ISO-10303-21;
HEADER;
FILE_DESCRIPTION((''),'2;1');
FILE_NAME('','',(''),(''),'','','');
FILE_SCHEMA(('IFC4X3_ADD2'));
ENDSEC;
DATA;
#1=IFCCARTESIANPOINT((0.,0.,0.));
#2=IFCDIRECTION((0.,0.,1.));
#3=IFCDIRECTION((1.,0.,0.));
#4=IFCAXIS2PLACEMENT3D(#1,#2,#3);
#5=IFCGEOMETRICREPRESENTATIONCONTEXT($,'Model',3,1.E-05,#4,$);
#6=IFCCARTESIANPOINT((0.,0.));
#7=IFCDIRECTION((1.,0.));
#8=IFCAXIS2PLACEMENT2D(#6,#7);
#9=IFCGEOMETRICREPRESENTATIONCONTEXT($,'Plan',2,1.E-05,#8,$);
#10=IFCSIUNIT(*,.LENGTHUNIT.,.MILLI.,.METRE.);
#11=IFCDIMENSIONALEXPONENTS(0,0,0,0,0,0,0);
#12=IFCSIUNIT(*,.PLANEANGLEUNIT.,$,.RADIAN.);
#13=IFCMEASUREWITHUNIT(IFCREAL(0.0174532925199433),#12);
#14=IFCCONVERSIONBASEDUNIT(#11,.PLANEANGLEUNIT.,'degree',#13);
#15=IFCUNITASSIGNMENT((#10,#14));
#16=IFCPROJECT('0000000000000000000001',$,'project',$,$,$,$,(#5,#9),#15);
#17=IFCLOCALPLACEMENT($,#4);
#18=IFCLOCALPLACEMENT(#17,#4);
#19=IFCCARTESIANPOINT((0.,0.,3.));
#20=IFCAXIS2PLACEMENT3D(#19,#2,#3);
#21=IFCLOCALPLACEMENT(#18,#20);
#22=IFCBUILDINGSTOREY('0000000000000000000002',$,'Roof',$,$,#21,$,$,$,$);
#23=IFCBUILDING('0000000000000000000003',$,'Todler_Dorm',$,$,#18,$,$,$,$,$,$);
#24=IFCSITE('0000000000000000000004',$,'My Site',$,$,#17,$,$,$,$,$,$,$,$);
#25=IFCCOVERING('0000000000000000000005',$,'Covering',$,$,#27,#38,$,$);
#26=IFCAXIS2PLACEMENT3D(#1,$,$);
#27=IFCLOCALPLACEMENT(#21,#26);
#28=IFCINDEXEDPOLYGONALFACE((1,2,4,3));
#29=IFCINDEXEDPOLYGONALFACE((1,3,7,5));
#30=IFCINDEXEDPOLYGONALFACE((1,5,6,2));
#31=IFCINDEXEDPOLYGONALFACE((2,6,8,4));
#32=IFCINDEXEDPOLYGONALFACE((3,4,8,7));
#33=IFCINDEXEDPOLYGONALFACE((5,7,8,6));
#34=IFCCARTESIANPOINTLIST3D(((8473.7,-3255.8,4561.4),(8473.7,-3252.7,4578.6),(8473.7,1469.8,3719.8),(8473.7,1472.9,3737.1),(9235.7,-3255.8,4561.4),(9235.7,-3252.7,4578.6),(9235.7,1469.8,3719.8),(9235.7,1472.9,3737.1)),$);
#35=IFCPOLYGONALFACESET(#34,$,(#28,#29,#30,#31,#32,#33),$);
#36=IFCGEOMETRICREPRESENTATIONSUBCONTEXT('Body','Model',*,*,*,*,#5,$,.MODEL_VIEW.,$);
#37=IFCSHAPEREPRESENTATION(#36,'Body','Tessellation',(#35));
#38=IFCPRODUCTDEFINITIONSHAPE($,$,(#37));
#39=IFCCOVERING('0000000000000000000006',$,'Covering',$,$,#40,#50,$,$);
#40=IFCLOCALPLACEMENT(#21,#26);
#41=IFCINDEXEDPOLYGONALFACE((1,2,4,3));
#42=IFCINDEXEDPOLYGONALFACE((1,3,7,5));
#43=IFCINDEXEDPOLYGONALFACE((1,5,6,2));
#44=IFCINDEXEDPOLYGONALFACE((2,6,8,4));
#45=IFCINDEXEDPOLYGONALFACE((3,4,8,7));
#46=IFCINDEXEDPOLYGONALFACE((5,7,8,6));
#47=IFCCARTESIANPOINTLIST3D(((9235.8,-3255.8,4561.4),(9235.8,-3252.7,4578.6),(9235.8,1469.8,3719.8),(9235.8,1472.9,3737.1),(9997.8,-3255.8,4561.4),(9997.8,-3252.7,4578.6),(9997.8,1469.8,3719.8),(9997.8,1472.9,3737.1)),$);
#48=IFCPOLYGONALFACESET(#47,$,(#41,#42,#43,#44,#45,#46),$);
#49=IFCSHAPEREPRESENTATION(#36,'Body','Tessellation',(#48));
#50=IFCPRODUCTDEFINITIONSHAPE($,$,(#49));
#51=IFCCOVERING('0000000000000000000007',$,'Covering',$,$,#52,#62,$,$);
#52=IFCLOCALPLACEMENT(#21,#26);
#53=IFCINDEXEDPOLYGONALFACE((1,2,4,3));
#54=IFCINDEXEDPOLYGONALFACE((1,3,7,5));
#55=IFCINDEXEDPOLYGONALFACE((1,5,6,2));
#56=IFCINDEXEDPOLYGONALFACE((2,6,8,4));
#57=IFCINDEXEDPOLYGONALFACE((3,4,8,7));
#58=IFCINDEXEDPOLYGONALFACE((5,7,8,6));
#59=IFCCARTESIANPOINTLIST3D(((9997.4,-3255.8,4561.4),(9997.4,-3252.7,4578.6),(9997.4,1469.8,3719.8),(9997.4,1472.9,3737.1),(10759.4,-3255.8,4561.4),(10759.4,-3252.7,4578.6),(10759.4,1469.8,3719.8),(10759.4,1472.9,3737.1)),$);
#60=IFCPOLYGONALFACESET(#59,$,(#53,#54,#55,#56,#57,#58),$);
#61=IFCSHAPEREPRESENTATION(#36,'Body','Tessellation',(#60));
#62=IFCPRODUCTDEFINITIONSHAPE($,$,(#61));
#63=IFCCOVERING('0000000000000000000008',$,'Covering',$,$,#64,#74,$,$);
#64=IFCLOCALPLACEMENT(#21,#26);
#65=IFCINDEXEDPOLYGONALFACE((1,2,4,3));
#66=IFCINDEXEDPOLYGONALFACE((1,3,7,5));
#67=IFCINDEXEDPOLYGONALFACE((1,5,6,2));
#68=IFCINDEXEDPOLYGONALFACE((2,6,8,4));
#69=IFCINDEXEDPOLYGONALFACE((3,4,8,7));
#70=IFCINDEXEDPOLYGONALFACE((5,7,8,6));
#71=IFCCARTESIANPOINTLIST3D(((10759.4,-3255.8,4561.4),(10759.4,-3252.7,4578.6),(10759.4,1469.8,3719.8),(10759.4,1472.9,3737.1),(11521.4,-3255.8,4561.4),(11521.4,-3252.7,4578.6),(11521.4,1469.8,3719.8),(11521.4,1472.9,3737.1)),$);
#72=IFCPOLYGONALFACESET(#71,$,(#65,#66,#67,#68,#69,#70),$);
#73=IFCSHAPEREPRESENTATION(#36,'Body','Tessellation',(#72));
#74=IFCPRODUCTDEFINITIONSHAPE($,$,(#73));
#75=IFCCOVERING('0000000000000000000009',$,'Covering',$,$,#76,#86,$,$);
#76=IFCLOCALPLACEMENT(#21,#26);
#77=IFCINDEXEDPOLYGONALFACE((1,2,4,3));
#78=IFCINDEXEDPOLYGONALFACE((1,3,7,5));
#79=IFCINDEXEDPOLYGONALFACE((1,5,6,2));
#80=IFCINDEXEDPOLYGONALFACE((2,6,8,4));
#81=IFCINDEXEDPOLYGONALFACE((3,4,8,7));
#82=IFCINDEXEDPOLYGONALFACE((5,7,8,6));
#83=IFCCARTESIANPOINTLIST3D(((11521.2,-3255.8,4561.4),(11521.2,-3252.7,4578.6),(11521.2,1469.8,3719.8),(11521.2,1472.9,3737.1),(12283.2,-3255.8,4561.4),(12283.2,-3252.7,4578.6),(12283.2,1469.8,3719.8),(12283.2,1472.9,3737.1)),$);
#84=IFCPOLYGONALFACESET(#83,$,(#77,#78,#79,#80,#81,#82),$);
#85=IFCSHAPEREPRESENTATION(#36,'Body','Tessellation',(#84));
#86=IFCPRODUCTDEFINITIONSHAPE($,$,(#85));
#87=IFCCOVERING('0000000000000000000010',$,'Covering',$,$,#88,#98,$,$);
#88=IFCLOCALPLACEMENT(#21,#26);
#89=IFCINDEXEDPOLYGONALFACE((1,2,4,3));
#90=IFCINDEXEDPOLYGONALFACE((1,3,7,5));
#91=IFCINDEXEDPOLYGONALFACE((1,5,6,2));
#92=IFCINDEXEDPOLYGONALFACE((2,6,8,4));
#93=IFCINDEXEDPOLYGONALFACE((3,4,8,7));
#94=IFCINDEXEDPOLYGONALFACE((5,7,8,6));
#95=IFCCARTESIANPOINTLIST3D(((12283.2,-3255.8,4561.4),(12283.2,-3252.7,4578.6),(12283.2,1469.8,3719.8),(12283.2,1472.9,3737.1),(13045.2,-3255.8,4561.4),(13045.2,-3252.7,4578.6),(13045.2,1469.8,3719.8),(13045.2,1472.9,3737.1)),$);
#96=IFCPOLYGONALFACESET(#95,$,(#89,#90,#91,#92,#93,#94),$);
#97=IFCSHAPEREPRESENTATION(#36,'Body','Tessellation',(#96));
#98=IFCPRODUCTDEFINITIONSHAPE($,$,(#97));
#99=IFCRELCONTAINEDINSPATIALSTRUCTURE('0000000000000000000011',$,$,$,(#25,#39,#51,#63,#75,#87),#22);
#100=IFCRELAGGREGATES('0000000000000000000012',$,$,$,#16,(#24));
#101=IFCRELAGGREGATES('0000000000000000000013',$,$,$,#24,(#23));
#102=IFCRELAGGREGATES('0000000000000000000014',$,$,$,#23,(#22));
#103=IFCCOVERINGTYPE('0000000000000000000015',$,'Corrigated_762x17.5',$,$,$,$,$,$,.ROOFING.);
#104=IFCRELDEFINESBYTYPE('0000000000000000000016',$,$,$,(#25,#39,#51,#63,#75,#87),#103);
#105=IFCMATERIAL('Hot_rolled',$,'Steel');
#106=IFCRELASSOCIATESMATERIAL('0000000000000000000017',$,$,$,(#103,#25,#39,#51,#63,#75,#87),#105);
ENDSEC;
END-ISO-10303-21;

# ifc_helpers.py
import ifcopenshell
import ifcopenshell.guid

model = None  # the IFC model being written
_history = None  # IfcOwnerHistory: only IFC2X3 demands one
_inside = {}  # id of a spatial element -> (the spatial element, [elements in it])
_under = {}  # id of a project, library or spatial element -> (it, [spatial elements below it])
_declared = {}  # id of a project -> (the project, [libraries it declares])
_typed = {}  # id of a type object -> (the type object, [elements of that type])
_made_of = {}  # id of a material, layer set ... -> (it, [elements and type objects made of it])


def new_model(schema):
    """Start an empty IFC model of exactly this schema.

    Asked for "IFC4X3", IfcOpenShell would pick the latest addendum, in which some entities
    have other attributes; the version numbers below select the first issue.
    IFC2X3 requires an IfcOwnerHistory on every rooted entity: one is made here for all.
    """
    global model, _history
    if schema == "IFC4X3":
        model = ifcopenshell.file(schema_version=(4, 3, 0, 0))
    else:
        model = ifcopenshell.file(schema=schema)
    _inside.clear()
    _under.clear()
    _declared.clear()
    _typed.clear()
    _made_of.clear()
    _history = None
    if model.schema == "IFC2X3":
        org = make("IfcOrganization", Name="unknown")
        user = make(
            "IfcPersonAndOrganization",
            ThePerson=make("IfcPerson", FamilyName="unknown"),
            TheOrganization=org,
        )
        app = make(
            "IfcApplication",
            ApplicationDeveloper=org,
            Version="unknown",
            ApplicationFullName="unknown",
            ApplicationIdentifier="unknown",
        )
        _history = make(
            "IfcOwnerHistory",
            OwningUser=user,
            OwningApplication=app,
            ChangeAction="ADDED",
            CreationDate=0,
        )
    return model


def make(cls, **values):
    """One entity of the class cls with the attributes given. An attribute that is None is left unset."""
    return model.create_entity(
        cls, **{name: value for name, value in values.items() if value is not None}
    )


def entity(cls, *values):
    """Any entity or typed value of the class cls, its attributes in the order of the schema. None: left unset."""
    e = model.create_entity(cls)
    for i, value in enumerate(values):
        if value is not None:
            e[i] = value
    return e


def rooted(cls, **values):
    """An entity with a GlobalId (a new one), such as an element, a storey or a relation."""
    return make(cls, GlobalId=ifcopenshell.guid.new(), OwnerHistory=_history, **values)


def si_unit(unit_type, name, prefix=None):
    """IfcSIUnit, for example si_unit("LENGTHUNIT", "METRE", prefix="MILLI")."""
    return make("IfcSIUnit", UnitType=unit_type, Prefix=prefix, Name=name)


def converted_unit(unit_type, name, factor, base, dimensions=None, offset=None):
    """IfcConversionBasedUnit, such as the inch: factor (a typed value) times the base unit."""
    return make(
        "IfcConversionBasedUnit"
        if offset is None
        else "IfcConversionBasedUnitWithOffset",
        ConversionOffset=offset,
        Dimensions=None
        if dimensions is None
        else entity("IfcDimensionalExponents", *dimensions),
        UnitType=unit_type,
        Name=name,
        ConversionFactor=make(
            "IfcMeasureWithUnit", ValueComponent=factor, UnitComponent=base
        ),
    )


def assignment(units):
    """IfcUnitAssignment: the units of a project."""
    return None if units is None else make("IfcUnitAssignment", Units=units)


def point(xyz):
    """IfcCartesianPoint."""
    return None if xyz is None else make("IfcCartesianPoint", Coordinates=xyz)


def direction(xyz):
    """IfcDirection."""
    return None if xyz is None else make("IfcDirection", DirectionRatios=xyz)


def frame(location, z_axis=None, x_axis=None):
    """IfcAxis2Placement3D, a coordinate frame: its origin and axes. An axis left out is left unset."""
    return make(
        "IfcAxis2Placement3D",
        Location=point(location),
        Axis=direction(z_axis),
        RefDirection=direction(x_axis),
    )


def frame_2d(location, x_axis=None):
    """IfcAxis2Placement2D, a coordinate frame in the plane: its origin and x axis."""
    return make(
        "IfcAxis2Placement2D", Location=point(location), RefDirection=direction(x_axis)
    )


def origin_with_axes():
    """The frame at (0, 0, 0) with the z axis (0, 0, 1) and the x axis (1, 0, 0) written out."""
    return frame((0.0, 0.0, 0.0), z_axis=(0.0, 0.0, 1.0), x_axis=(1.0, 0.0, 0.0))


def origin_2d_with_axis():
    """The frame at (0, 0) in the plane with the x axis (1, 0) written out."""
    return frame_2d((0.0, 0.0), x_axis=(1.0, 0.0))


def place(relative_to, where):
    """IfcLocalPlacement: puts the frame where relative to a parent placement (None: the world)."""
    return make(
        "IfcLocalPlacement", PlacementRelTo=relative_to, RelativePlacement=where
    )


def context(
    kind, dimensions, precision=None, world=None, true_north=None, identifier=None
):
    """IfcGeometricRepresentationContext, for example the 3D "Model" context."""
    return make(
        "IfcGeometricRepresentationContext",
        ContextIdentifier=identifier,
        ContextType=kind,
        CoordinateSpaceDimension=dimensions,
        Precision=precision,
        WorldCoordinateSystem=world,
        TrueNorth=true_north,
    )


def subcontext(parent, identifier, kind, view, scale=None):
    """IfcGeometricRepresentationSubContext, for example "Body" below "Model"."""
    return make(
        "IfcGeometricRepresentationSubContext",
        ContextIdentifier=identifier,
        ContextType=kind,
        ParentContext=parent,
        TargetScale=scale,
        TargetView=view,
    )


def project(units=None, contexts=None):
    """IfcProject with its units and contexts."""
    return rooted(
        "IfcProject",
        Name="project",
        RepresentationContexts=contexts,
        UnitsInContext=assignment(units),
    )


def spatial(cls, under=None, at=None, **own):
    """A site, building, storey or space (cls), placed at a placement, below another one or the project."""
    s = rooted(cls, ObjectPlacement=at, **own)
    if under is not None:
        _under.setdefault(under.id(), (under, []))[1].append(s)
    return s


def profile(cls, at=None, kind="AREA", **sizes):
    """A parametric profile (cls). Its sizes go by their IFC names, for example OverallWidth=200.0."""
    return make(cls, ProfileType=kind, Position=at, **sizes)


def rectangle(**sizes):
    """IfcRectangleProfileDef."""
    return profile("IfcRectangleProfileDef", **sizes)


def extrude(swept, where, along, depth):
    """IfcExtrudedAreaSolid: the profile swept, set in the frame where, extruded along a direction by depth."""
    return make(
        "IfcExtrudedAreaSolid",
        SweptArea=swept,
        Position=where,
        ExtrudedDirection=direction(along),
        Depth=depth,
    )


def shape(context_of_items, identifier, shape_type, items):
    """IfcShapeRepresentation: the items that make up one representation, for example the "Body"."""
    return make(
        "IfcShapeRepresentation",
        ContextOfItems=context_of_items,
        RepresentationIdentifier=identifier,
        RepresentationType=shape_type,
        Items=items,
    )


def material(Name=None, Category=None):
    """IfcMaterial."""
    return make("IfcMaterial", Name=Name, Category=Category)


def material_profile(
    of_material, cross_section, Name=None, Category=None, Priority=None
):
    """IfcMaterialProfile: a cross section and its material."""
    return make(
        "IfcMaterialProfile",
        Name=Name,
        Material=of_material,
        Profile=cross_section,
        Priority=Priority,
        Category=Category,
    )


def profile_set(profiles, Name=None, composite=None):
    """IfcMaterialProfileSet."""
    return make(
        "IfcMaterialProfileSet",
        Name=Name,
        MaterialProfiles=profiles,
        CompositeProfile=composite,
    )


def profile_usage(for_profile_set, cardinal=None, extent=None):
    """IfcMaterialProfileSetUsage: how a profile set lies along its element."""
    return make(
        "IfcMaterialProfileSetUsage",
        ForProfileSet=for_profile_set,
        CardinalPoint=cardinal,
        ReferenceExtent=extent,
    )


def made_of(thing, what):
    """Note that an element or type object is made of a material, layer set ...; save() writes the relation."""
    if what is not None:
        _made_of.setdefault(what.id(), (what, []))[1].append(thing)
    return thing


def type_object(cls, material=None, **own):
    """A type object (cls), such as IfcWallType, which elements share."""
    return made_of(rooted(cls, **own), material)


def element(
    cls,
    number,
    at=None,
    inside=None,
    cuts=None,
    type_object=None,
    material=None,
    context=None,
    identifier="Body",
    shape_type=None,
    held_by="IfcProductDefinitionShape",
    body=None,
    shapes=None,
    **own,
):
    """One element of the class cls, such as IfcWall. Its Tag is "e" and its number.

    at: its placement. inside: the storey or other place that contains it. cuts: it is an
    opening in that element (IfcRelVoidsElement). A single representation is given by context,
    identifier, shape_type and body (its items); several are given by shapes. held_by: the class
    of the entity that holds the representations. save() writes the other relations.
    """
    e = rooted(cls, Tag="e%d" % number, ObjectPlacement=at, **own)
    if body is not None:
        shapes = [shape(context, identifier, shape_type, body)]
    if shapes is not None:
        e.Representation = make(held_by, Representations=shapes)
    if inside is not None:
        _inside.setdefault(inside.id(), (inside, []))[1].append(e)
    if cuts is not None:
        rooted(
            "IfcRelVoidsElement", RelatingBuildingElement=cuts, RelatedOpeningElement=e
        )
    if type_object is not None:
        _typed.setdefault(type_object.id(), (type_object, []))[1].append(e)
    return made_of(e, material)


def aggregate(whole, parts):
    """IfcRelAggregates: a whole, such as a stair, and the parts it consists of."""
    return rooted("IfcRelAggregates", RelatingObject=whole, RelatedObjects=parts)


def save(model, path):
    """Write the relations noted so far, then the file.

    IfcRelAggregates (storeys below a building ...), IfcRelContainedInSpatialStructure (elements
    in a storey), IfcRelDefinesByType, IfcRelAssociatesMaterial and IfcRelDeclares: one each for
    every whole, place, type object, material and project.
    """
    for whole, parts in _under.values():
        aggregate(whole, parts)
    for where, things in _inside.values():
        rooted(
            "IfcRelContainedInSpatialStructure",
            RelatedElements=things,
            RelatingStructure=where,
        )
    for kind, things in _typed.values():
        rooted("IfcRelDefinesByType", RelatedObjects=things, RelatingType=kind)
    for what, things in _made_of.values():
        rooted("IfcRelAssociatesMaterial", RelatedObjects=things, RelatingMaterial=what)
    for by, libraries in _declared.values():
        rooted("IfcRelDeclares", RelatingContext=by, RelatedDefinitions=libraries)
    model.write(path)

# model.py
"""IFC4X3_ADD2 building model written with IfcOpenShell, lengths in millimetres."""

from ifc_helpers import new_model, entity, si_unit, converted_unit, frame, origin_with_axes, origin_2d_with_axis, place, context, subcontext, project, spatial, rectangle, extrude, material, material_profile, profile_set, profile_usage, type_object, element, save


model = new_model("IFC4X3_ADD2")

# Units and contexts
model_context = context("Model", 3, precision=1e-05, world=origin_with_axes())
plan_context = context("Plan", 2, precision=1e-05, world=origin_2d_with_axis())
body_context = subcontext(model_context, "Body", "Model", "MODEL_VIEW")
ifc_project = project(units=[si_unit("LENGTHUNIT", "METRE", prefix="MILLI"), converted_unit("PLANEANGLEUNIT", "degree", entity("IfcReal", 0.0174532925199433), si_unit("PLANEANGLEUNIT", "RADIAN"), dimensions=[0, 0, 0, 0, 0, 0, 0])], contexts=[model_context, plan_context])

# Site, building, storey
site_placement = place(None, origin_with_axes())
site = spatial("IfcSite", under=ifc_project, at=site_placement, Name="My Site")
building_placement = place(site_placement, origin_with_axes())
building = spatial("IfcBuilding", under=site, at=building_placement, Name="Todler_Dorm")
storey_placement = place(building_placement, frame((0.0, 0.0, 3.0), z_axis=(0.0, 0.0, 1.0), x_axis=(1.0, 0.0, 0.0)))
storey = spatial("IfcBuildingStorey", under=building, at=storey_placement, Name="Roof")

# Coverings
ifc_material_1 = material(Name="Hot_rolled", Category="Steel")
ifc_material_profile = material_profile(ifc_material_1, rectangle(XDim=762.0, YDim=17.5))
ifc_profile_set = profile_set([ifc_material_profile])
covering_type = type_object("IfcCoveringType", Name="Corrigated_762x17.5", PredefinedType="ROOFING", material=ifc_profile_set)
ifc_profile_usage_1 = profile_usage(ifc_profile_set, cardinal=5)
covering_1_placement = place(storey_placement, frame((8854.7, 1471.4, 3728.4), z_axis=(0.0, -0.98451, 0.175329), x_axis=(1.0, 0.0, 0.0)))
element("IfcCovering", 1, at=covering_1_placement, inside=storey, type_object=covering_type, material=ifc_profile_usage_1, Name="Covering", context=body_context, shape_type="SweptSolid", body=[
    extrude(rectangle(XDim=762.0, YDim=17.5), origin_with_axes(), (0.0, 0.0, 1.0), 4800.0),
])
ifc_profile_usage_2 = profile_usage(ifc_profile_set, cardinal=5)
covering_2_placement = place(storey_placement, frame((9616.8, 1471.4, 3728.4), z_axis=(0.0, -0.98451, 0.175329), x_axis=(1.0, 0.0, 0.0)))
element("IfcCovering", 2, at=covering_2_placement, inside=storey, type_object=covering_type, material=ifc_profile_usage_2, Name="Covering", context=body_context, shape_type="SweptSolid", body=[
    extrude(rectangle(XDim=762.0, YDim=17.5), origin_with_axes(), (0.0, 0.0, 1.0), 4800.0),
])
ifc_profile_usage_3 = profile_usage(ifc_profile_set, cardinal=5)
covering_3_placement = place(storey_placement, frame((10378.4, 1471.4, 3728.4), z_axis=(0.0, -0.98451, 0.175329), x_axis=(1.0, 0.0, 0.0)))
element("IfcCovering", 3, at=covering_3_placement, inside=storey, type_object=covering_type, material=ifc_profile_usage_3, Name="Covering", context=body_context, shape_type="SweptSolid", body=[
    extrude(rectangle(XDim=762.0, YDim=17.5), origin_with_axes(), (0.0, 0.0, 1.0), 4800.0),
])
ifc_profile_usage_4 = profile_usage(ifc_profile_set, cardinal=5)
covering_4_placement = place(storey_placement, frame((11140.4, 1471.4, 3728.4), z_axis=(0.0, -0.98451, 0.175329), x_axis=(1.0, 0.0, 0.0)))
element("IfcCovering", 4, at=covering_4_placement, inside=storey, type_object=covering_type, material=ifc_profile_usage_4, Name="Covering", context=body_context, shape_type="SweptSolid", body=[
    extrude(rectangle(XDim=762.0, YDim=17.5), origin_with_axes(), (0.0, 0.0, 1.0), 4800.0),
])
ifc_profile_usage_5 = profile_usage(ifc_profile_set, cardinal=5)
covering_5_placement = place(storey_placement, frame((11902.2, 1471.4, 3728.4), z_axis=(0.0, -0.98451, 0.175329), x_axis=(1.0, 0.0, 0.0)))
element("IfcCovering", 5, at=covering_5_placement, inside=storey, type_object=covering_type, material=ifc_profile_usage_5, Name="Covering", context=body_context, shape_type="SweptSolid", body=[
    extrude(rectangle(XDim=762.0, YDim=17.5), origin_with_axes(), (0.0, 0.0, 1.0), 4800.0),
])
ifc_profile_usage_6 = profile_usage(ifc_profile_set, cardinal=5)
covering_6_placement = place(storey_placement, frame((12664.2, 1471.4, 3728.4), z_axis=(0.0, -0.98451, 0.175329), x_axis=(1.0, 0.0, 0.0)))
element("IfcCovering", 6, at=covering_6_placement, inside=storey, type_object=covering_type, material=ifc_profile_usage_6, Name="Covering", context=body_context, shape_type="SweptSolid", body=[
    extrude(rectangle(XDim=762.0, YDim=17.5), origin_with_axes(), (0.0, 0.0, 1.0), 4800.0),
])

save(model, "model.ifc")
